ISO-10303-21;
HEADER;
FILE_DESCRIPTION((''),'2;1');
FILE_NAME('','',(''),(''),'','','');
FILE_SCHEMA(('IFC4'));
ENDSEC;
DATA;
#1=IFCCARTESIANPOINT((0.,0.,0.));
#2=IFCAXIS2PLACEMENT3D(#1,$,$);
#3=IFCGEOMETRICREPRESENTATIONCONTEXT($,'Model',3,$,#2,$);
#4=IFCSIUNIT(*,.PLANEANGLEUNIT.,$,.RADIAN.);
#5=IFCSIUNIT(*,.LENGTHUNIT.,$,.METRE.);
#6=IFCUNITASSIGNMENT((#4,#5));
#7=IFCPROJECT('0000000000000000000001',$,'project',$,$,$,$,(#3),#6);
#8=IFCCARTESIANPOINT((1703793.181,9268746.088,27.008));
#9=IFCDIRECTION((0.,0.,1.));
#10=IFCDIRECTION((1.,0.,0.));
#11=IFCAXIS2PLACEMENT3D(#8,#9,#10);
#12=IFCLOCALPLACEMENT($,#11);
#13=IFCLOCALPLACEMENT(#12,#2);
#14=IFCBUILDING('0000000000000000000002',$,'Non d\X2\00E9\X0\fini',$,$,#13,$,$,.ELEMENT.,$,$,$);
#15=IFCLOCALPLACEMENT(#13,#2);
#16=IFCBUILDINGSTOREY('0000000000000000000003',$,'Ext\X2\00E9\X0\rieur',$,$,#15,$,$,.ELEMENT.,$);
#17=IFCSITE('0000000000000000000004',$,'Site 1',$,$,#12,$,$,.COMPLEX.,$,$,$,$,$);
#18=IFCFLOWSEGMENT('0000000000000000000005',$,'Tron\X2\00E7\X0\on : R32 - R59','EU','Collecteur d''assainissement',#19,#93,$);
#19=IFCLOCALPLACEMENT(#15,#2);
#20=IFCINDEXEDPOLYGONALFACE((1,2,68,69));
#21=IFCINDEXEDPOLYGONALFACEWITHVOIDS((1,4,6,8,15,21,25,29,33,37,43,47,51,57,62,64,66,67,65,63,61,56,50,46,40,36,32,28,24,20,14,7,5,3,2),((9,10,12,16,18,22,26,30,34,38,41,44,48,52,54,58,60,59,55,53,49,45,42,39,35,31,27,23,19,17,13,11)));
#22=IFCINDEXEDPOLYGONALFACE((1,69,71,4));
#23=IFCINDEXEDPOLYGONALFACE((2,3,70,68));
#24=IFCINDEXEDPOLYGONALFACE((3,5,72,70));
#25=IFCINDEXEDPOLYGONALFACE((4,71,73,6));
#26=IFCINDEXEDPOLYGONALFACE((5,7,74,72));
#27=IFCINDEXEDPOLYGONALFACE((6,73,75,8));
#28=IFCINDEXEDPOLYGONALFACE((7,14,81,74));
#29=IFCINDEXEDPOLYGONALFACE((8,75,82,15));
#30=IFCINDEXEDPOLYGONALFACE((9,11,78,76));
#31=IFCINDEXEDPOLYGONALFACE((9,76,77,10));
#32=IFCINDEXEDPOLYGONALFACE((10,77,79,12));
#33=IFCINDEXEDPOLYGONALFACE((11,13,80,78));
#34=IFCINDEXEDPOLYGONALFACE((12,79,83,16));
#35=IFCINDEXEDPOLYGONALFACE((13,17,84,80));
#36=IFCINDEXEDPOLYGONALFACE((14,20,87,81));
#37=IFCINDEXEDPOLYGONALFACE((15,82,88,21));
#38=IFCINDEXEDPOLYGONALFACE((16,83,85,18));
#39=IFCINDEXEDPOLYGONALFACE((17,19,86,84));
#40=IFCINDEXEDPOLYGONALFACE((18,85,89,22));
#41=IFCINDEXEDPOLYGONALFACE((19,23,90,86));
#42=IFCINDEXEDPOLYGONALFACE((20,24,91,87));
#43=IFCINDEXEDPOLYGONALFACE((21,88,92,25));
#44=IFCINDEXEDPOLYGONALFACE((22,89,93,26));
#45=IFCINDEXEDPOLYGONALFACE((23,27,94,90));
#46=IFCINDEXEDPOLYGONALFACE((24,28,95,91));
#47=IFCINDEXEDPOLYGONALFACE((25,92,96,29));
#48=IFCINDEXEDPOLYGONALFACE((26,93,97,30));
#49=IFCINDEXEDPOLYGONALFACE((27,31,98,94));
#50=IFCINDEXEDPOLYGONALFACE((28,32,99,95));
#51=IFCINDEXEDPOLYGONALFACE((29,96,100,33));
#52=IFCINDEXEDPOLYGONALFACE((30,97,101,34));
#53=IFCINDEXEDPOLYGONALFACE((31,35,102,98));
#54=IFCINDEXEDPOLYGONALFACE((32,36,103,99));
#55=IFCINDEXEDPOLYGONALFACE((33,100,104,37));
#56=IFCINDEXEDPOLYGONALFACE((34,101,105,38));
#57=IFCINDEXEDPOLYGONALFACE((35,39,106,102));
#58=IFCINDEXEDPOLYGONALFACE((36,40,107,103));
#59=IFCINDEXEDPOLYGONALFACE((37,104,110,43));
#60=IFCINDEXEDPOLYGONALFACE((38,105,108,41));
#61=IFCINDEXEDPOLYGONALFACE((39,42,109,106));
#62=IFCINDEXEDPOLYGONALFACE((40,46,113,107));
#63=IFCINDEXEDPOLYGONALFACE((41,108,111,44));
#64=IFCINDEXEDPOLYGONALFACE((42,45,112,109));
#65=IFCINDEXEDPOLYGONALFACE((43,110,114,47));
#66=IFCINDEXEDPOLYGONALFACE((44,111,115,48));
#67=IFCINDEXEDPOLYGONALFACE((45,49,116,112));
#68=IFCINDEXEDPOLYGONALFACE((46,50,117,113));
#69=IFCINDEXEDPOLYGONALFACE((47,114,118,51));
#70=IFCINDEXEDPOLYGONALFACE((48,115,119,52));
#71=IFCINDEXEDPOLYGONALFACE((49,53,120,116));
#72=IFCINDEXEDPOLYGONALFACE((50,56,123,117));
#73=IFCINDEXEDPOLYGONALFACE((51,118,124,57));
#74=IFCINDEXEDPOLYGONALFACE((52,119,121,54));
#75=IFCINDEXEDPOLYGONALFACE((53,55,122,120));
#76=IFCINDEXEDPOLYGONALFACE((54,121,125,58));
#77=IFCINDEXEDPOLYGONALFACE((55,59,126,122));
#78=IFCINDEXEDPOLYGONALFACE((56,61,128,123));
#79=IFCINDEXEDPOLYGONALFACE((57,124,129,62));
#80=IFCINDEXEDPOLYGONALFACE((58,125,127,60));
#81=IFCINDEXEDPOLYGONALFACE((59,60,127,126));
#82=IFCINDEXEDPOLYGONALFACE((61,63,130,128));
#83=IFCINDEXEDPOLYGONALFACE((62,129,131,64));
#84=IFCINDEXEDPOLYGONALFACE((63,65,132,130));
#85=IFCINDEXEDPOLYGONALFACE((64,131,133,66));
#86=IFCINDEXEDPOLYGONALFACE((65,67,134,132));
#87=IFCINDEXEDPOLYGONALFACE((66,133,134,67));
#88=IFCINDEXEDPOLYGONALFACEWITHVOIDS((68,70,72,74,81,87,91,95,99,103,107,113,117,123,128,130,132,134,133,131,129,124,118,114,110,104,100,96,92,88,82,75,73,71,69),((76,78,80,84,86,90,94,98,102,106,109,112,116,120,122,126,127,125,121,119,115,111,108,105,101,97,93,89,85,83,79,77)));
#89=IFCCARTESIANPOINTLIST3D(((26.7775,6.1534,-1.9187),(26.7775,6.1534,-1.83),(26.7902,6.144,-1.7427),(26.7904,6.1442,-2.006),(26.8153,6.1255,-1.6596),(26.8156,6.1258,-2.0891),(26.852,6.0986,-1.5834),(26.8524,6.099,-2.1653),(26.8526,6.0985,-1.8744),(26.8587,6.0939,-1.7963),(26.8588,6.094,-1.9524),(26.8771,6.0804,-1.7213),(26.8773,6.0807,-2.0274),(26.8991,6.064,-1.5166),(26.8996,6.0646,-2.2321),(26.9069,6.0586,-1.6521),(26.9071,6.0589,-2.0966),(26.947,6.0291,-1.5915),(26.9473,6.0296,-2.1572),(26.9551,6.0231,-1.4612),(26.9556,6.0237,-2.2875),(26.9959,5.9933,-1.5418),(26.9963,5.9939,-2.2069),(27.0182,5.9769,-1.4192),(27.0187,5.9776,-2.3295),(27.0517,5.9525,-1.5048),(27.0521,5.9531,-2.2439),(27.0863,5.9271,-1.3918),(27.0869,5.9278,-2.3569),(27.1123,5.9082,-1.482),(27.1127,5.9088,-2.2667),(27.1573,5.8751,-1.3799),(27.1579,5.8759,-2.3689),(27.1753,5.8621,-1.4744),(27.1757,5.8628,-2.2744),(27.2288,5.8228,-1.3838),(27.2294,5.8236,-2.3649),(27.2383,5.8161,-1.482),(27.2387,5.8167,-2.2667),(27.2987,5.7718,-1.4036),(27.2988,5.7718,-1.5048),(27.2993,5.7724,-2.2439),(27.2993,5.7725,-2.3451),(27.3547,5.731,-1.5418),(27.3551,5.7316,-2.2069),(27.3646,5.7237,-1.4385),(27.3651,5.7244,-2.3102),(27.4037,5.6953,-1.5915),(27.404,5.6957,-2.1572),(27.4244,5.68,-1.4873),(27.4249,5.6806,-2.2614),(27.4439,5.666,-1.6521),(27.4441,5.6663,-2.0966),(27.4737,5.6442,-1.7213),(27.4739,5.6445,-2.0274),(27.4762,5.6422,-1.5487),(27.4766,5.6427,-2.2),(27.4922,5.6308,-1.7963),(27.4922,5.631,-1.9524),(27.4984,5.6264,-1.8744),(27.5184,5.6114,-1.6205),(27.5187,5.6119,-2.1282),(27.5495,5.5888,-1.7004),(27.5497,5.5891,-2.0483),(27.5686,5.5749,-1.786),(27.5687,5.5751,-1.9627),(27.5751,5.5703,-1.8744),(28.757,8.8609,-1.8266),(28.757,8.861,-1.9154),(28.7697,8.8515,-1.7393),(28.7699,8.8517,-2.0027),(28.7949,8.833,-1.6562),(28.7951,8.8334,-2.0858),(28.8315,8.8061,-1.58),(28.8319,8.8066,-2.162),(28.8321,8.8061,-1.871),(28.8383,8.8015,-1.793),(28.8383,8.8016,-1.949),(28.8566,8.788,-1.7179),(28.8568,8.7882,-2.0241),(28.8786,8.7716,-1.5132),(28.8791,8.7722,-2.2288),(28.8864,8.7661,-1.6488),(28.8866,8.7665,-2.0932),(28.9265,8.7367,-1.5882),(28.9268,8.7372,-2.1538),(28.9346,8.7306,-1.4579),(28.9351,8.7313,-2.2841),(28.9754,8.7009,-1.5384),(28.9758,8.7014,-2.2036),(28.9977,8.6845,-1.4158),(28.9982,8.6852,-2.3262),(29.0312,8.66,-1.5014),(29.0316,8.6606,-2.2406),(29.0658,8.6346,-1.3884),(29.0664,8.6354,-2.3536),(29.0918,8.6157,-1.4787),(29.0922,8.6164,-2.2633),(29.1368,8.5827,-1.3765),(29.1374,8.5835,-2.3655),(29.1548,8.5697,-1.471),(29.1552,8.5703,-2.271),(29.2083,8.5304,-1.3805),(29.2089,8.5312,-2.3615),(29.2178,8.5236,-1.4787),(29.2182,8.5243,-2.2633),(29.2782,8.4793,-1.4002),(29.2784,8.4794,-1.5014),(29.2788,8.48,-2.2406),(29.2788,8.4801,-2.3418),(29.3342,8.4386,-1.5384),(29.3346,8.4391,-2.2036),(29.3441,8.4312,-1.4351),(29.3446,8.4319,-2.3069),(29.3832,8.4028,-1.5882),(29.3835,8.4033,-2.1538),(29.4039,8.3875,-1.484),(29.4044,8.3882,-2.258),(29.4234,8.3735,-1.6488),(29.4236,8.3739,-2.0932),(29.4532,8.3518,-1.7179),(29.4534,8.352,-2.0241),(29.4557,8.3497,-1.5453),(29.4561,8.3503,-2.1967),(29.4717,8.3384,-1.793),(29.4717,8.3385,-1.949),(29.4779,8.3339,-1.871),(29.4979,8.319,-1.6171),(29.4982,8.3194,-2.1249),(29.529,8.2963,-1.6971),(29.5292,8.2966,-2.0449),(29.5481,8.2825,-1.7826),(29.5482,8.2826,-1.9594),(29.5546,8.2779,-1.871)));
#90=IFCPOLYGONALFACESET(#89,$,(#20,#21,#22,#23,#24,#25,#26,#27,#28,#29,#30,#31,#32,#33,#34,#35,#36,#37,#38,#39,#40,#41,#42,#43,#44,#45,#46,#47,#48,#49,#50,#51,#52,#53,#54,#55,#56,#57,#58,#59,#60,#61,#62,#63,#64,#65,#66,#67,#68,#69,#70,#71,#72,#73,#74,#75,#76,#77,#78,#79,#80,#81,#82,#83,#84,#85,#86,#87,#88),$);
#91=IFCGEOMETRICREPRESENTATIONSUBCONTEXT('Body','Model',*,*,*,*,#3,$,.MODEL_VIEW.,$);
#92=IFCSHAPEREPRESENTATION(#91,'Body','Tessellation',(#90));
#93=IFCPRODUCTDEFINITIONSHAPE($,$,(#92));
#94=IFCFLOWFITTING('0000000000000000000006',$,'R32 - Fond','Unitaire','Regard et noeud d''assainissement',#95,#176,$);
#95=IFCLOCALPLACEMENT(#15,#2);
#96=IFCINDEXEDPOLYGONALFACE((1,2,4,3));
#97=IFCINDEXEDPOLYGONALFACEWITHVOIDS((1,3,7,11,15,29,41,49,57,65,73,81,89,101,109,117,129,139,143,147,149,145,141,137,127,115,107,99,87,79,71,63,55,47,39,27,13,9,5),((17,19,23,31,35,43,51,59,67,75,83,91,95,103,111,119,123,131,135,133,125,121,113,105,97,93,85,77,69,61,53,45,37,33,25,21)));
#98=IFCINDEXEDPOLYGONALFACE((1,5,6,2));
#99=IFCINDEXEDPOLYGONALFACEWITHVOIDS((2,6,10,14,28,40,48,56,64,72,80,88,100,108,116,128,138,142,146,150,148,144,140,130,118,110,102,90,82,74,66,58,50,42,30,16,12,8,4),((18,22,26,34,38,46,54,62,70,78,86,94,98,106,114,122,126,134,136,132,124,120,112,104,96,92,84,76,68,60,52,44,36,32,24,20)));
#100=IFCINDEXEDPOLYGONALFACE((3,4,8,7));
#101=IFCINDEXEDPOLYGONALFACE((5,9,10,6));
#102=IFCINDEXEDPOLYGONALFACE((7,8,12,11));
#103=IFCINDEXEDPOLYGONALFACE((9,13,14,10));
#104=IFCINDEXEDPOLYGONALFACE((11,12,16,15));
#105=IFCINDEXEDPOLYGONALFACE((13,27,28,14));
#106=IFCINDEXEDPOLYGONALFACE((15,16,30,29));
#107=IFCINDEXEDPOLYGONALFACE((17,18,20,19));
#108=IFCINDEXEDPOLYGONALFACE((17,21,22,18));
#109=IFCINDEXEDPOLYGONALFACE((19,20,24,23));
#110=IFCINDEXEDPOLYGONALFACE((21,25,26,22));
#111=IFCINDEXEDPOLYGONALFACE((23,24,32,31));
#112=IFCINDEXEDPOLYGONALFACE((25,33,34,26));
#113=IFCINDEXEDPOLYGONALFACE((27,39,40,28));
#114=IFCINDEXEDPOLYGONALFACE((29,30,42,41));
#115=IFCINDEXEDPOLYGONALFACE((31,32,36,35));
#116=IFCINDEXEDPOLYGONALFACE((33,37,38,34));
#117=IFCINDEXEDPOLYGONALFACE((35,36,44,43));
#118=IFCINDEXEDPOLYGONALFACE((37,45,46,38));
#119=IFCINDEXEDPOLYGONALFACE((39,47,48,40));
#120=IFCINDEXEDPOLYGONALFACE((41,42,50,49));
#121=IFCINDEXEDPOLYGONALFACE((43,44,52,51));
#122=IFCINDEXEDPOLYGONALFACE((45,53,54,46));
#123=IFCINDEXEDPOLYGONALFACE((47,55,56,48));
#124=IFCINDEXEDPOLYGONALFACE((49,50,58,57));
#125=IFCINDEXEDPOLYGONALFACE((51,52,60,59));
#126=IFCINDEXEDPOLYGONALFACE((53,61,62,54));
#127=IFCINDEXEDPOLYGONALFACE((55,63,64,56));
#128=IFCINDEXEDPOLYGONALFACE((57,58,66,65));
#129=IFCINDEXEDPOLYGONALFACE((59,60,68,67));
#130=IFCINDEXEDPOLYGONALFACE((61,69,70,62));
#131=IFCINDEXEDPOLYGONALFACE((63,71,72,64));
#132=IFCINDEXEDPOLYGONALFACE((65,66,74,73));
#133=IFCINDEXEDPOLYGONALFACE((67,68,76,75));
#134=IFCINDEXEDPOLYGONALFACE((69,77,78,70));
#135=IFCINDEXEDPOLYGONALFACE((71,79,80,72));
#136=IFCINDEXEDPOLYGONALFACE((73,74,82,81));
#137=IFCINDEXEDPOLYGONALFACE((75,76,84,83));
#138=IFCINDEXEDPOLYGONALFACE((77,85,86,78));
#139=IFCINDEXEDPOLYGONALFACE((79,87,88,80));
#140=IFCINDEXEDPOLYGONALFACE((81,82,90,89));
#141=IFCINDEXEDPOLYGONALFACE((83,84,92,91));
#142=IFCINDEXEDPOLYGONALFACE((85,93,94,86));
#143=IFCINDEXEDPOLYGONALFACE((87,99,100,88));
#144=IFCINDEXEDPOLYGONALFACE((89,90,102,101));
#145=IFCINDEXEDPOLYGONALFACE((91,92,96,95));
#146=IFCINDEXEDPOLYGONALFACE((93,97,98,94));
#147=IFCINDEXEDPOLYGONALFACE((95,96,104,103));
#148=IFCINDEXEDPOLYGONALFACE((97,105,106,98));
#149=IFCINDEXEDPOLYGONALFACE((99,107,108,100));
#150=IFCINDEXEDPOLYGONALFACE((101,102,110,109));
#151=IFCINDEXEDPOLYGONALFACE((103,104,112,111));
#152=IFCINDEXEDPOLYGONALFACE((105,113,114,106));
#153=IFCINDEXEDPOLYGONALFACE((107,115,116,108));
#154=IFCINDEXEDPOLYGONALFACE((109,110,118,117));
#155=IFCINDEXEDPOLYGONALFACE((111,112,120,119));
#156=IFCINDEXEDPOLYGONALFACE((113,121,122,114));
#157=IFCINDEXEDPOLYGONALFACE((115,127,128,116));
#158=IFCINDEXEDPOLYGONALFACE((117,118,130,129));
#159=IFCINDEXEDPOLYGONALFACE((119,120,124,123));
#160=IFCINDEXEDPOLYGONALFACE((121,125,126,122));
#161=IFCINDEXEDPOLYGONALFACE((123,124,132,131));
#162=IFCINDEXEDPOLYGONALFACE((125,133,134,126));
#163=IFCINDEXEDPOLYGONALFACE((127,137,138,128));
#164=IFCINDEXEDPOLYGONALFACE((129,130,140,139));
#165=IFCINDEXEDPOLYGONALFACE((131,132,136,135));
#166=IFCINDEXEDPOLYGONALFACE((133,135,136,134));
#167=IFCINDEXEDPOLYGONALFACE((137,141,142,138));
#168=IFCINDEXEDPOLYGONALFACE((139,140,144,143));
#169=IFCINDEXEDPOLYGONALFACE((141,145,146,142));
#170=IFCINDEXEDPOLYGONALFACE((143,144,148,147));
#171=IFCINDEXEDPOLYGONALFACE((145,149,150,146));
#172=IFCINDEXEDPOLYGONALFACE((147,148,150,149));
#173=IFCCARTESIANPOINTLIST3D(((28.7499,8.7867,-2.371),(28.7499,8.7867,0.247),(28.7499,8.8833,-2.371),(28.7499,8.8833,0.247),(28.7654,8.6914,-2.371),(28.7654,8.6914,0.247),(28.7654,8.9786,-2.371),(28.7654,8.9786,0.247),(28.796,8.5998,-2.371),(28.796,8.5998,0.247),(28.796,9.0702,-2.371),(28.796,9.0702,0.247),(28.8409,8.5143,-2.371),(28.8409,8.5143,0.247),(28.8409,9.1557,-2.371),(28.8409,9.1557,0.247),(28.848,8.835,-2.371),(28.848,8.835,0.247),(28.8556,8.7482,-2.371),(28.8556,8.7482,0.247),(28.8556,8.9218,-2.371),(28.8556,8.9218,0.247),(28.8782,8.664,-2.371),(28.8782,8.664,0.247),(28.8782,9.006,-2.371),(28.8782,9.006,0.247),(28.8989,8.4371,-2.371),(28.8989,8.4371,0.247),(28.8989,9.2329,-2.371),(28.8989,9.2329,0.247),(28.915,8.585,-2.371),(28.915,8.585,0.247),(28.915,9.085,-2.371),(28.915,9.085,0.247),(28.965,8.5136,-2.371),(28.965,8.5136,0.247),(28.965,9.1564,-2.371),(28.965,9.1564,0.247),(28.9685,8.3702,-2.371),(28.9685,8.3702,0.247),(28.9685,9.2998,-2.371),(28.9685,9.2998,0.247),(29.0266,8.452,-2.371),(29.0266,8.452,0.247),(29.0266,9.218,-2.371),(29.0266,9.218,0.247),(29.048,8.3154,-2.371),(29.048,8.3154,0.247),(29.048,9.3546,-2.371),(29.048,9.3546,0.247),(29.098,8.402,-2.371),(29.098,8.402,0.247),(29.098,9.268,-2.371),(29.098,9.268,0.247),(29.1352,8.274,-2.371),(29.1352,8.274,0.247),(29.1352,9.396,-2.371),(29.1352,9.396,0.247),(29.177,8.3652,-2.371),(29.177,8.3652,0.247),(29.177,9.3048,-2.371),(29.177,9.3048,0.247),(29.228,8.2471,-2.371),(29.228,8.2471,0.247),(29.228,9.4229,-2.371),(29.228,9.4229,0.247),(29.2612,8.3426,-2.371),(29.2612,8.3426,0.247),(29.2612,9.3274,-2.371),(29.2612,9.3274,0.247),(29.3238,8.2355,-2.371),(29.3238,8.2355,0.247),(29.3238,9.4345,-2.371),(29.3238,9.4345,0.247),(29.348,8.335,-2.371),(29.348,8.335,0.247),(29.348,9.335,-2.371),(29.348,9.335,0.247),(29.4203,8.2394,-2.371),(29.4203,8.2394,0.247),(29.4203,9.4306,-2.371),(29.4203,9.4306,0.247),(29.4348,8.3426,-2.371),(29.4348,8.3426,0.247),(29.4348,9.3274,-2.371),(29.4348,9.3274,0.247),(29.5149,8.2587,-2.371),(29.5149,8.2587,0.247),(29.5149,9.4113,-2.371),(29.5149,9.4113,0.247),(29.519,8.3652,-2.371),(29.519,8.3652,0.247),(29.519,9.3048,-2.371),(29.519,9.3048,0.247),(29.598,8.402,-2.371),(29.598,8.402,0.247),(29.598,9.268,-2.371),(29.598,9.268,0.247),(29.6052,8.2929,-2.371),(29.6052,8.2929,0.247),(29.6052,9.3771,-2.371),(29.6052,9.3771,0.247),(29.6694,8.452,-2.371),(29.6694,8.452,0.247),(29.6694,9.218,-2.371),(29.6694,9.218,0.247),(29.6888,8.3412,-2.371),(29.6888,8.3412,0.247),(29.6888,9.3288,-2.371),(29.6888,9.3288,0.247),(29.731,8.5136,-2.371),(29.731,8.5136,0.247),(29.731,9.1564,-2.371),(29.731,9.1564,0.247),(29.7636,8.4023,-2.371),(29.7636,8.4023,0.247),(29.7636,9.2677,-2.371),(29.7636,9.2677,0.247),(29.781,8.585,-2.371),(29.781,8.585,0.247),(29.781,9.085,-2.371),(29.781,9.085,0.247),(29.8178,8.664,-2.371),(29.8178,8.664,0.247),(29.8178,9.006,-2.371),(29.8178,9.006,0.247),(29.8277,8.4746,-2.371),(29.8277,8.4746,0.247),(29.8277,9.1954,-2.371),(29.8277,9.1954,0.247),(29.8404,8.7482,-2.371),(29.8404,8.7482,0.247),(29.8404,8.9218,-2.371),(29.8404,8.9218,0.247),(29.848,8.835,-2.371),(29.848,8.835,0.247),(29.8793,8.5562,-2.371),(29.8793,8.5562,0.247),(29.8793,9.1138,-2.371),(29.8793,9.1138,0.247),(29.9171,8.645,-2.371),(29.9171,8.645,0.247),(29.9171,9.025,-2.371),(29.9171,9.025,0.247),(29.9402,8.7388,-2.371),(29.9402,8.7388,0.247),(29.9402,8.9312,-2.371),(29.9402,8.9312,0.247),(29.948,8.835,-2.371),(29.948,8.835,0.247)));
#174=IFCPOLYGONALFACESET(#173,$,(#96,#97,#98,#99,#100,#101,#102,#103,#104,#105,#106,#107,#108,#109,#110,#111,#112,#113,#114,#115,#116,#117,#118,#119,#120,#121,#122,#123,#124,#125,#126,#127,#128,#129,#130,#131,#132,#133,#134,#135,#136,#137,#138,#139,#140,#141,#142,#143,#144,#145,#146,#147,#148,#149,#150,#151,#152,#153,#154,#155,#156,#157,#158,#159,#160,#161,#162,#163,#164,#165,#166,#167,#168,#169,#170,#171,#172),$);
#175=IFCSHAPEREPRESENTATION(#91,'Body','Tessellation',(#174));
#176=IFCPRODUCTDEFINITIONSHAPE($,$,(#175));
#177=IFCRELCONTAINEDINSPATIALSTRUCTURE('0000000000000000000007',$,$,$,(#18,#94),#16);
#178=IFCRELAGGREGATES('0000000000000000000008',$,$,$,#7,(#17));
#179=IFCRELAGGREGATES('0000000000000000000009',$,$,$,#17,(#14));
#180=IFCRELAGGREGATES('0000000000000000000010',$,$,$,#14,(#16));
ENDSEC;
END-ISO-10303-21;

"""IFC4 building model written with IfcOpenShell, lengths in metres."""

from ifc_helpers import new_model, si_unit, frame, origin, origin_2d, place, context, subcontext, project, spatial, hollow_circle, extrude, element, save


model = new_model("IFC4")

# Units and contexts
model_context = context("Model", 3, world=origin())
body_context = subcontext(model_context, "Body", "Model", "MODEL_VIEW")
ifc_project = project(units=[si_unit("PLANEANGLEUNIT", "RADIAN"), si_unit("LENGTHUNIT", "METRE")], contexts=[model_context])

# Site, building, storey
site_placement = place(None, frame((1703793.181, 9268746.088, 27.008), z_axis=(0.0, 0.0, 1.0), x_axis=(1.0, 0.0, 0.0)))
site = spatial("IfcSite", under=ifc_project, at=site_placement, Name="Site 1", CompositionType="COMPLEX")
building_placement = place(site_placement, origin())
building = spatial("IfcBuilding", under=site, at=building_placement, Name="Non défini", CompositionType="ELEMENT")
storey_placement = place(building_placement, origin())
storey = spatial("IfcBuildingStorey", under=building, at=storey_placement, Name="Extérieur", CompositionType="ELEMENT")

# Flow segment
flow_segment_1_placement = place(storey_placement, origin())
element("IfcFlowSegment", 1, at=flow_segment_1_placement, inside=storey, Name="Tronçon : R32 - R59", Description="EU", ObjectType="Collecteur d'assainissement", context=body_context, shape_type="SweptSolid", body=[
    extrude(hollow_circle(Radius=0.495, WallThickness=0.095, at=origin_2d()), frame((29.155, 8.57, -1.871), z_axis=(-0.59, -0.807, -0.001), x_axis=(0.807, -0.59, 0.0)), (0.0, 0.0, 1.0), 3.354),
])

# Flow fitting
flow_fitting_1_placement = place(storey_placement, origin())
element("IfcFlowFitting", 2, at=flow_fitting_1_placement, inside=storey, Name="R32 - Fond", Description="Unitaire", ObjectType="Regard et noeud d'assainissement", context=body_context, shape_type="SweptSolid", body=[
    extrude(hollow_circle(Radius=0.6, WallThickness=0.1, at=origin_2d()), frame((29.348, 8.835, -2.371), z_axis=(0.0, 0.0, 1.0), x_axis=(1.0, 0.0, 0.0)), (0.0, 0.0, 1.0), 2.618),
])

save(model, "model.ifc")
